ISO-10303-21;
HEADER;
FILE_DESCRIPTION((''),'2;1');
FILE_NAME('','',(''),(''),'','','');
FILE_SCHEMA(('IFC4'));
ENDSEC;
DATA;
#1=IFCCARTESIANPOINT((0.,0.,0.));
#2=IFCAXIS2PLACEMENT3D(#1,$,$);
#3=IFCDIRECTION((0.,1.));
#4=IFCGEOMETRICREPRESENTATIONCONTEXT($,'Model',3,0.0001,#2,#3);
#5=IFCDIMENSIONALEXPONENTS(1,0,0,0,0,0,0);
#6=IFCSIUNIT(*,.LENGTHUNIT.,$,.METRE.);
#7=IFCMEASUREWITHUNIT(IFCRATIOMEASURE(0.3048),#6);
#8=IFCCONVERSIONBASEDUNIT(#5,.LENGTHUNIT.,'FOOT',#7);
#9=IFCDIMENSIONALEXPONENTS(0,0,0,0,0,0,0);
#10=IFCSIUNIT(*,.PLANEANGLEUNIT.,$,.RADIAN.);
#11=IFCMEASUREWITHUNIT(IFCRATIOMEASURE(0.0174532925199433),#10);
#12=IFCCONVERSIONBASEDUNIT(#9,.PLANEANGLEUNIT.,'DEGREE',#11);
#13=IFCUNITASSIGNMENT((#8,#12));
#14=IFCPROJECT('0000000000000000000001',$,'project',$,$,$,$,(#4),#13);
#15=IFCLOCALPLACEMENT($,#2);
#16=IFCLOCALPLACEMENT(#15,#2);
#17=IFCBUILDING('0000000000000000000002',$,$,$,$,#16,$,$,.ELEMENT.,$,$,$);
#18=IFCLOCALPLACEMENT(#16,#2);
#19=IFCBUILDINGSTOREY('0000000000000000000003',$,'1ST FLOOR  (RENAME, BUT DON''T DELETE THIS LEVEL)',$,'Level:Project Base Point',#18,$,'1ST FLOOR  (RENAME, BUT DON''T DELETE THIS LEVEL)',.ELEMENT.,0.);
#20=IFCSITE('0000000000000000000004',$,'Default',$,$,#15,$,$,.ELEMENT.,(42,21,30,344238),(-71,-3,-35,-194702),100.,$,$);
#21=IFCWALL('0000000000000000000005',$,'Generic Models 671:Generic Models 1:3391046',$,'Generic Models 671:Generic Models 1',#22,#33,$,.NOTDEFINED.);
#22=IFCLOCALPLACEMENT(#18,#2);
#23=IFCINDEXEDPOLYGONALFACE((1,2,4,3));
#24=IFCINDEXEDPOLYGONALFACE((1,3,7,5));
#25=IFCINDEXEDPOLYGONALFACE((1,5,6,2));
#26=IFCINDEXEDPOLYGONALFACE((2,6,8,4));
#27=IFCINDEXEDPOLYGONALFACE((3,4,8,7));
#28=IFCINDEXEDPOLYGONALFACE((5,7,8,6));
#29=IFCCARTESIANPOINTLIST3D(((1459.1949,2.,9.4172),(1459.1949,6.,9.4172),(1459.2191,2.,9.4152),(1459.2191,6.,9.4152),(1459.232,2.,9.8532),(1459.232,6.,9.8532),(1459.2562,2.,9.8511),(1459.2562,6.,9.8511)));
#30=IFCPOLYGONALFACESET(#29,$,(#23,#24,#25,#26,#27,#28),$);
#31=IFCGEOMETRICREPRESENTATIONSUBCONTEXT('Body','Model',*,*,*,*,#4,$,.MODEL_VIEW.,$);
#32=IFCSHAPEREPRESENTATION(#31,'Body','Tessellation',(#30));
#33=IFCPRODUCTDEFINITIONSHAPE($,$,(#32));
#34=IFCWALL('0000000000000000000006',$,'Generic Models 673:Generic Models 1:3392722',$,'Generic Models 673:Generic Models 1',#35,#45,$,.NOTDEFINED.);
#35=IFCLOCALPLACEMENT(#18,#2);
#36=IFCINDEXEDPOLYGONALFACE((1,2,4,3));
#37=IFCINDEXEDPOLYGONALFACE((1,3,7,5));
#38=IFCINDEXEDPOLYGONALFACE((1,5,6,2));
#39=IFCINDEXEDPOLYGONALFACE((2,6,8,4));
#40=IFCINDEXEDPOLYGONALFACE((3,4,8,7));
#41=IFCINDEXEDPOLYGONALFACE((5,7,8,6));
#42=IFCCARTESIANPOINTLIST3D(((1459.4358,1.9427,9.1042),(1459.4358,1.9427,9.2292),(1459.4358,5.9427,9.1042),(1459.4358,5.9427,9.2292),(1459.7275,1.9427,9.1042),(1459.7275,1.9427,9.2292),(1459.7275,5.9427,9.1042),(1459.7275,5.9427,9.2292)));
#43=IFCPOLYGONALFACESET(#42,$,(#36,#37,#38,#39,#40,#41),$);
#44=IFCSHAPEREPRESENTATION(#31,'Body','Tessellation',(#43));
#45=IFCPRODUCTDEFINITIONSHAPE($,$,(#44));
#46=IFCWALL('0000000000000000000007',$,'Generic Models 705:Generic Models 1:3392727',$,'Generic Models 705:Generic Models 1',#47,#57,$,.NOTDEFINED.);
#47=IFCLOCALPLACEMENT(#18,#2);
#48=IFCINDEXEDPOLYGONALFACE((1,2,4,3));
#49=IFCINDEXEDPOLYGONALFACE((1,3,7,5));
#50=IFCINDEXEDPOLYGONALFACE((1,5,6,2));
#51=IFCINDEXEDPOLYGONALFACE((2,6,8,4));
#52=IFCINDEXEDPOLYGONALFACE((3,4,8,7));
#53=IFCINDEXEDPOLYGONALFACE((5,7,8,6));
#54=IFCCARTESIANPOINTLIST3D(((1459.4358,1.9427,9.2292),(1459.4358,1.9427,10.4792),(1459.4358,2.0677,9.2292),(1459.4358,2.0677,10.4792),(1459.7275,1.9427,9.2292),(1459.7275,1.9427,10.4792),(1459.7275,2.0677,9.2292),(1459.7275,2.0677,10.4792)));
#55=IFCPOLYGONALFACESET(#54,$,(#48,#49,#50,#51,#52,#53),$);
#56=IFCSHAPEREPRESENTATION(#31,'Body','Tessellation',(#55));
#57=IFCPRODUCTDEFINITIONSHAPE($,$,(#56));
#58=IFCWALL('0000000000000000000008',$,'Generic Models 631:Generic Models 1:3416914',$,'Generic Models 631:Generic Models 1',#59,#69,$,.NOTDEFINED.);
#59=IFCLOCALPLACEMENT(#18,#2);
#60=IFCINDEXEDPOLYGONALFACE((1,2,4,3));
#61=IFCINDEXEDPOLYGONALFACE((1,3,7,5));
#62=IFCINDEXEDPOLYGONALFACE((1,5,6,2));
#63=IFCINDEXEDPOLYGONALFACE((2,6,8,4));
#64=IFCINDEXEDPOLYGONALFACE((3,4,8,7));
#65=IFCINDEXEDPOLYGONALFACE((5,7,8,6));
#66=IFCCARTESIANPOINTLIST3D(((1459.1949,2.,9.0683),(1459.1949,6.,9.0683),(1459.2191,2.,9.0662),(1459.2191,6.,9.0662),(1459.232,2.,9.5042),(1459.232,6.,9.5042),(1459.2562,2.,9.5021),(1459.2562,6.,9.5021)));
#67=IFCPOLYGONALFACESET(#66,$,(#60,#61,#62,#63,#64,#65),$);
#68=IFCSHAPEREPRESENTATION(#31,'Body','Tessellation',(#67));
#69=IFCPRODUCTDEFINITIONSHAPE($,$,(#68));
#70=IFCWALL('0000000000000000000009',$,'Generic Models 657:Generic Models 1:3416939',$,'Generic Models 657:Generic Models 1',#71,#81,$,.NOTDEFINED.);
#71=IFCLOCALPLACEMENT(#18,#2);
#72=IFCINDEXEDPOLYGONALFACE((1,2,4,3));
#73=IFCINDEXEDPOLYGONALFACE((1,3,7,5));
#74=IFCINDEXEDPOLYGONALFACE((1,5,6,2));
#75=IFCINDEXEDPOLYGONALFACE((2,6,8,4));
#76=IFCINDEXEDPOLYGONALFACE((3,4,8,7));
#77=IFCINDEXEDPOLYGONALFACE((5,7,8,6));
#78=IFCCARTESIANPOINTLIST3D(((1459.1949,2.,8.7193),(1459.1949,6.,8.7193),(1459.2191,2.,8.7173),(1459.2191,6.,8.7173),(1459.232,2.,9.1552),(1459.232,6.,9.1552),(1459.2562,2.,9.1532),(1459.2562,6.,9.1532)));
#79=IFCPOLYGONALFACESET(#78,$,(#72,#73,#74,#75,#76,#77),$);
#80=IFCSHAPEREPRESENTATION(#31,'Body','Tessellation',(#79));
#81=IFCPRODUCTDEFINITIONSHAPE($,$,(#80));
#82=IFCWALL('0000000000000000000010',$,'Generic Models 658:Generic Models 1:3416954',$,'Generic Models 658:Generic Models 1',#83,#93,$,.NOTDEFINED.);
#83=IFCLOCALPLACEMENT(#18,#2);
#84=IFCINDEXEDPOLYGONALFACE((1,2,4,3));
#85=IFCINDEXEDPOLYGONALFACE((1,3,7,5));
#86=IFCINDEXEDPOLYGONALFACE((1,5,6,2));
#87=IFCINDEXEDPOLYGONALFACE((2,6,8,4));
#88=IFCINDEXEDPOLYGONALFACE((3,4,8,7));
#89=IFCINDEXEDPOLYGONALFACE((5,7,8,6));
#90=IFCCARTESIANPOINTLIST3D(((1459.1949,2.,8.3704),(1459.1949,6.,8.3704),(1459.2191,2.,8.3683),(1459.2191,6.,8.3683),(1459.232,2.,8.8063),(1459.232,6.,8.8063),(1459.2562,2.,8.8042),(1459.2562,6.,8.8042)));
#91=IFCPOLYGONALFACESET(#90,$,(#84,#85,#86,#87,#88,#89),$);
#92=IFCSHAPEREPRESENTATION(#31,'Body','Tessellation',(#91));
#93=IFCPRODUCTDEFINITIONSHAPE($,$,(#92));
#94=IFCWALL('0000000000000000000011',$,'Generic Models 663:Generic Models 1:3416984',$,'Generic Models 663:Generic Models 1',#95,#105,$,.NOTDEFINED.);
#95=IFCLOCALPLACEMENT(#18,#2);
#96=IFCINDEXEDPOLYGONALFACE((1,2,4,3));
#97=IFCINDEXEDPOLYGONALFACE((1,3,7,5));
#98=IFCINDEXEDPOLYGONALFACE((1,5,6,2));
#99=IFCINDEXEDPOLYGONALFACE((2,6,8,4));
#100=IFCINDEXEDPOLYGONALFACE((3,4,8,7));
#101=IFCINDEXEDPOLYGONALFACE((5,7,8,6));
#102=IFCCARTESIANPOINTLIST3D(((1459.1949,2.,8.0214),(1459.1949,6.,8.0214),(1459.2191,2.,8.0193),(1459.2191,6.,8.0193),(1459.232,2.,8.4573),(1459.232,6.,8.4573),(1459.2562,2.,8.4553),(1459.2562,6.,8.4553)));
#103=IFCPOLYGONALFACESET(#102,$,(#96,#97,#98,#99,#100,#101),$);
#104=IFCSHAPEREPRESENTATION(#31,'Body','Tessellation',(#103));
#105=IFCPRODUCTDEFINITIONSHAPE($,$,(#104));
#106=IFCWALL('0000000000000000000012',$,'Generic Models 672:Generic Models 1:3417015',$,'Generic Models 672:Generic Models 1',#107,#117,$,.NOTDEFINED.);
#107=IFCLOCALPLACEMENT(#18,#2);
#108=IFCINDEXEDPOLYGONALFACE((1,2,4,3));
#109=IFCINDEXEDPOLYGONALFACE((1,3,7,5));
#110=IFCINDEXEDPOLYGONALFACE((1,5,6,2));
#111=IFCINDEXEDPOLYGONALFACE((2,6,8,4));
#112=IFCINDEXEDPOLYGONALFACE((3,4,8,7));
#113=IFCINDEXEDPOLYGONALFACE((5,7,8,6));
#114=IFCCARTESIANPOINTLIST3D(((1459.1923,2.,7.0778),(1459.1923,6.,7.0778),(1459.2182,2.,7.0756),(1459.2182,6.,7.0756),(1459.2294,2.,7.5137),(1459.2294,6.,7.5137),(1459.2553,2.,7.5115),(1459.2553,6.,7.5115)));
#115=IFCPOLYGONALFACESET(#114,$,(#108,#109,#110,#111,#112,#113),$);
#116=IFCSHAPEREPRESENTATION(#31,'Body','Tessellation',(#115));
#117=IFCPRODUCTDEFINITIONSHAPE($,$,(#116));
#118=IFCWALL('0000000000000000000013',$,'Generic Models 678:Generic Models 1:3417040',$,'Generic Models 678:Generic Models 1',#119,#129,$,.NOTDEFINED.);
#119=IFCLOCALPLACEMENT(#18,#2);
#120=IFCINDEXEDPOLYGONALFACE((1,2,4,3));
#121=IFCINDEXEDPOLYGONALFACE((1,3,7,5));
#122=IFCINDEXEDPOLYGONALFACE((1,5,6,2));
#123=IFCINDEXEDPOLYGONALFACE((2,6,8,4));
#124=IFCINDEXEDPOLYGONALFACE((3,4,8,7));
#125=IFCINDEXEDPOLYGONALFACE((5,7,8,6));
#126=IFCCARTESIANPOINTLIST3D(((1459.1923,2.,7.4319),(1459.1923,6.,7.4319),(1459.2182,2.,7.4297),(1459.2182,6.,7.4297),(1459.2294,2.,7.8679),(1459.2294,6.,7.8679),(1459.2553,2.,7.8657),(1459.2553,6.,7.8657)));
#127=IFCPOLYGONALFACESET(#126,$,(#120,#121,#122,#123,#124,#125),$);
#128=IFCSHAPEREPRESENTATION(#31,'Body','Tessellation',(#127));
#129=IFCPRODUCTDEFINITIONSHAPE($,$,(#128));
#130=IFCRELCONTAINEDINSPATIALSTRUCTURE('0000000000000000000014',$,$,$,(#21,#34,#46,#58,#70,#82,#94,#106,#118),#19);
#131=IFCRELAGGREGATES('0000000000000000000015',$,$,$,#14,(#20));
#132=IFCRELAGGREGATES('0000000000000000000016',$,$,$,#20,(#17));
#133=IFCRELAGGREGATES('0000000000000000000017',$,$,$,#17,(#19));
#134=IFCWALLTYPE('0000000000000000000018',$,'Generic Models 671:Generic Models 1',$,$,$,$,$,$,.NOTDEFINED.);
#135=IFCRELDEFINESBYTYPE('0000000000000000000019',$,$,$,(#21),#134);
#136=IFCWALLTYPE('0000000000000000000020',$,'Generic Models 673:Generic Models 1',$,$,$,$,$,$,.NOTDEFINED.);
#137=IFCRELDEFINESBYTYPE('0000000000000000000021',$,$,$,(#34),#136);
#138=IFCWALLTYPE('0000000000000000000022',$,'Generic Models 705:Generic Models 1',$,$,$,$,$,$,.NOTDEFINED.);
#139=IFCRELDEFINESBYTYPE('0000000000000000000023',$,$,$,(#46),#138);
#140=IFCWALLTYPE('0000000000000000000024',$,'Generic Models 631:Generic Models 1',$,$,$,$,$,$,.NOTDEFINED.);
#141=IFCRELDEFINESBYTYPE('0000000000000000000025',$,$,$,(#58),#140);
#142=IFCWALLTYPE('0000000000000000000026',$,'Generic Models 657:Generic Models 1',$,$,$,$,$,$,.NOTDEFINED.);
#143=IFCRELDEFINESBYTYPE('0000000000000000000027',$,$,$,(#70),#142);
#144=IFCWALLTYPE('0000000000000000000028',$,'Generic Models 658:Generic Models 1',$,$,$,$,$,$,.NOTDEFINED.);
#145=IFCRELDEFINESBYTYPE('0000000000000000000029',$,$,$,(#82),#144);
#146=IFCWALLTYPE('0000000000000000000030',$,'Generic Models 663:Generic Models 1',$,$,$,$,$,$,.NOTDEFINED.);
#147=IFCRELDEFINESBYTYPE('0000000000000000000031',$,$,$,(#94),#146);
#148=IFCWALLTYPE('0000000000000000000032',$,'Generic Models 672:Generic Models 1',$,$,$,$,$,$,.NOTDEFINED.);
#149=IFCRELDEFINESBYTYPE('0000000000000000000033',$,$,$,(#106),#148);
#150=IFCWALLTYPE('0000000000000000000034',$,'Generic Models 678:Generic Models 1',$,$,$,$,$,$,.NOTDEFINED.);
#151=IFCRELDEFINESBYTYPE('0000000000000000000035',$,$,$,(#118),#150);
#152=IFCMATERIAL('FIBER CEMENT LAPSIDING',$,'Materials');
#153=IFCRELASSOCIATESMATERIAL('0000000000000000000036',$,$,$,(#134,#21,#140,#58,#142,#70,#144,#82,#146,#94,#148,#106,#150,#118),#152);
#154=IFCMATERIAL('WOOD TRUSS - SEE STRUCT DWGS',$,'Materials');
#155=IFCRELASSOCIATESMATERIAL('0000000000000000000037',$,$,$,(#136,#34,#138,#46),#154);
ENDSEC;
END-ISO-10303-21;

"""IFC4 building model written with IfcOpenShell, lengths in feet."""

from ifc_helpers import new_model, entity, si_unit, converted_unit, direction, frame, frame_2d, origin, place, context, subcontext, project, spatial, rectangle, extrude, material, type_object, element, save


model = new_model("IFC4")

# Units and contexts
model_context = context("Model", 3, precision=0.0001, world=origin(), true_north=direction((0.0, 1.0)))
body_context = subcontext(model_context, "Body", "Model", "MODEL_VIEW")
ifc_project = project(units=[converted_unit("LENGTHUNIT", "FOOT", entity("IfcRatioMeasure", 0.3048), si_unit("LENGTHUNIT", "METRE"), dimensions=[1, 0, 0, 0, 0, 0, 0]), converted_unit("PLANEANGLEUNIT", "DEGREE", entity("IfcRatioMeasure", 0.0174532925199433), si_unit("PLANEANGLEUNIT", "RADIAN"), dimensions=[0, 0, 0, 0, 0, 0, 0])], contexts=[model_context])

# Site, building, storey
site_placement = place(None, origin())
site = spatial("IfcSite", under=ifc_project, at=site_placement, Name="Default", CompositionType="ELEMENT", RefLatitude=(42, 21, 30, 344238), RefLongitude=(-71, -3, -35, -194702), RefElevation=100.0)
building_placement = place(site_placement, origin())
building = spatial("IfcBuilding", under=site, at=building_placement, CompositionType="ELEMENT")
storey_placement = place(building_placement, origin())
storey = spatial("IfcBuildingStorey", under=building, at=storey_placement, Name="1ST FLOOR  (RENAME, BUT DON'T DELETE THIS LEVEL)", ObjectType="Level:Project Base Point", LongName="1ST FLOOR  (RENAME, BUT DON'T DELETE THIS LEVEL)", CompositionType="ELEMENT", Elevation=0.0)

# Walls
ifc_material_1 = material(Name="FIBER CEMENT LAPSIDING", Category="Materials")
wall_type_1 = type_object("IfcWallType", Name="Generic Models 671:Generic Models 1", PredefinedType="NOTDEFINED", material=ifc_material_1)
wall_1_placement = place(storey_placement, frame((1459.1949, 2.0, 9.4152), z_axis=(0.0, 0.0, 1.0), x_axis=(0.0, 1.0, 0.0)))
element("IfcWall", 1, at=wall_1_placement, inside=storey, type_object=wall_type_1, material=ifc_material_1, Name="Generic Models 671:Generic Models 1:3391046", ObjectType="Generic Models 671:Generic Models 1", PredefinedType="NOTDEFINED", context=body_context, shape_type="SweptSolid", body=[
    extrude(rectangle(XDim=0.0242, YDim=4.0, at=frame_2d((0.0, 0.0), x_axis=(0.0, 1.0))), frame((2.0, -0.0121, 0.001), z_axis=(0.0, -0.0848, 0.996398), x_axis=(1.0, 0.0, 0.0)), (0.0, 0.0, 1.0), 0.4375),
])
ifc_material_2 = material(Name="WOOD TRUSS - SEE STRUCT DWGS", Category="Materials")
wall_type_2 = type_object("IfcWallType", Name="Generic Models 673:Generic Models 1", PredefinedType="NOTDEFINED", material=ifc_material_2)
wall_2_placement = place(storey_placement, frame((1459.4358, 1.9427, 9.1042), z_axis=(0.0, 0.0, 1.0), x_axis=(0.0, 1.0, 0.0)))
element("IfcWall", 2, at=wall_2_placement, inside=storey, type_object=wall_type_2, material=ifc_material_2, Name="Generic Models 673:Generic Models 1:3392722", ObjectType="Generic Models 673:Generic Models 1", PredefinedType="NOTDEFINED", context=body_context, shape_type="SweptSolid", body=[
    extrude(rectangle(XDim=4.0, YDim=0.2917, at=frame_2d((0.0, 0.0), x_axis=(1.0, 0.0))), frame((2.0, -0.1458, 0.0)), (0.0, 0.0, 1.0), 0.125),
])
wall_type_3 = type_object("IfcWallType", Name="Generic Models 705:Generic Models 1", PredefinedType="NOTDEFINED", material=ifc_material_2)
wall_3_placement = place(storey_placement, frame((1459.4358, 1.9427, 9.2292)))
element("IfcWall", 3, at=wall_3_placement, inside=storey, type_object=wall_type_3, material=ifc_material_2, Name="Generic Models 705:Generic Models 1:3392727", ObjectType="Generic Models 705:Generic Models 1", PredefinedType="NOTDEFINED", context=body_context, shape_type="SweptSolid", body=[
    extrude(rectangle(XDim=0.125, YDim=0.2917, at=frame_2d((0.0, 0.0), x_axis=(1.0, 0.0))), frame((0.1458, 0.0625, 0.0), z_axis=(0.0, 0.0, 1.0), x_axis=(0.0, 1.0, 0.0)), (0.0, 0.0, 1.0), 1.25),
])
wall_type_4 = type_object("IfcWallType", Name="Generic Models 631:Generic Models 1", PredefinedType="NOTDEFINED", material=ifc_material_1)
wall_4_placement = place(storey_placement, frame((1459.1949, 2.0, 9.0662), z_axis=(0.0, 0.0, 1.0), x_axis=(0.0, 1.0, 0.0)))
element("IfcWall", 4, at=wall_4_placement, inside=storey, type_object=wall_type_4, material=ifc_material_1, Name="Generic Models 631:Generic Models 1:3416914", ObjectType="Generic Models 631:Generic Models 1", PredefinedType="NOTDEFINED", context=body_context, shape_type="SweptSolid", body=[
    extrude(rectangle(XDim=0.0242, YDim=4.0, at=frame_2d((0.0, 0.0), x_axis=(0.0, 1.0))), frame((2.0, -0.0121, 0.001), z_axis=(0.0, -0.0848, 0.996398), x_axis=(1.0, 0.0, 0.0)), (0.0, 0.0, 1.0), 0.4375),
])
wall_type_5 = type_object("IfcWallType", Name="Generic Models 657:Generic Models 1", PredefinedType="NOTDEFINED", material=ifc_material_1)
wall_5_placement = place(storey_placement, frame((1459.1949, 2.0, 8.7173), z_axis=(0.0, 0.0, 1.0), x_axis=(0.0, 1.0, 0.0)))
element("IfcWall", 5, at=wall_5_placement, inside=storey, type_object=wall_type_5, material=ifc_material_1, Name="Generic Models 657:Generic Models 1:3416939", ObjectType="Generic Models 657:Generic Models 1", PredefinedType="NOTDEFINED", context=body_context, shape_type="SweptSolid", body=[
    extrude(rectangle(XDim=0.0242, YDim=4.0, at=frame_2d((0.0, 0.0), x_axis=(0.0, 1.0))), frame((2.0, -0.0121, 0.001), z_axis=(0.0, -0.0848, 0.996398), x_axis=(1.0, 0.0, 0.0)), (0.0, 0.0, 1.0), 0.4375),
])
wall_type_6 = type_object("IfcWallType", Name="Generic Models 658:Generic Models 1", PredefinedType="NOTDEFINED", material=ifc_material_1)
wall_6_placement = place(storey_placement, frame((1459.1949, 2.0, 8.3683), z_axis=(0.0, 0.0, 1.0), x_axis=(0.0, 1.0, 0.0)))
element("IfcWall", 6, at=wall_6_placement, inside=storey, type_object=wall_type_6, material=ifc_material_1, Name="Generic Models 658:Generic Models 1:3416954", ObjectType="Generic Models 658:Generic Models 1", PredefinedType="NOTDEFINED", context=body_context, shape_type="SweptSolid", body=[
    extrude(rectangle(XDim=0.0242, YDim=4.0, at=frame_2d((0.0, 0.0), x_axis=(0.0, 1.0))), frame((2.0, -0.0121, 0.001), z_axis=(0.0, -0.0848, 0.996398), x_axis=(1.0, 0.0, 0.0)), (0.0, 0.0, 1.0), 0.4375),
])
wall_type_7 = type_object("IfcWallType", Name="Generic Models 663:Generic Models 1", PredefinedType="NOTDEFINED", material=ifc_material_1)
wall_7_placement = place(storey_placement, frame((1459.1949, 2.0, 8.0193), z_axis=(0.0, 0.0, 1.0), x_axis=(0.0, 1.0, 0.0)))
element("IfcWall", 7, at=wall_7_placement, inside=storey, type_object=wall_type_7, material=ifc_material_1, Name="Generic Models 663:Generic Models 1:3416984", ObjectType="Generic Models 663:Generic Models 1", PredefinedType="NOTDEFINED", context=body_context, shape_type="SweptSolid", body=[
    extrude(rectangle(XDim=0.0242, YDim=4.0, at=frame_2d((0.0, 0.0), x_axis=(0.0, 1.0))), frame((2.0, -0.0121, 0.001), z_axis=(0.0, -0.0848, 0.996398), x_axis=(1.0, 0.0, 0.0)), (0.0, 0.0, 1.0), 0.4375),
])
wall_type_8 = type_object("IfcWallType", Name="Generic Models 672:Generic Models 1", PredefinedType="NOTDEFINED", material=ifc_material_1)
wall_8_placement = place(storey_placement, frame((1459.1923, 2.0, 7.0756), z_axis=(0.0, 0.0, 1.0), x_axis=(0.0, 1.0, 0.0)))
element("IfcWall", 8, at=wall_8_placement, inside=storey, type_object=wall_type_8, material=ifc_material_1, Name="Generic Models 672:Generic Models 1:3417015", ObjectType="Generic Models 672:Generic Models 1", PredefinedType="NOTDEFINED", context=body_context, shape_type="SweptSolid", body=[
    extrude(rectangle(XDim=0.026, YDim=4.0, at=frame_2d((0.0, 0.0), x_axis=(0.0, 1.0))), frame((2.0, -0.013, 0.0011), z_axis=(0.0, -0.0848, 0.996398), x_axis=(1.0, 0.0, 0.0)), (0.0, 0.0, 1.0), 0.4375),
])
wall_type_9 = type_object("IfcWallType", Name="Generic Models 678:Generic Models 1", PredefinedType="NOTDEFINED", material=ifc_material_1)
wall_9_placement = place(storey_placement, frame((1459.1923, 2.0, 7.4297), z_axis=(0.0, 0.0, 1.0), x_axis=(0.0, 1.0, 0.0)))
element("IfcWall", 9, at=wall_9_placement, inside=storey, type_object=wall_type_9, material=ifc_material_1, Name="Generic Models 678:Generic Models 1:3417040", ObjectType="Generic Models 678:Generic Models 1", PredefinedType="NOTDEFINED", context=body_context, shape_type="SweptSolid", body=[
    extrude(rectangle(XDim=0.026, YDim=4.0, at=frame_2d((0.0, 0.0), x_axis=(0.0, 1.0))), frame((2.0, -0.013, 0.0011), z_axis=(0.0, -0.0848, 0.996398), x_axis=(1.0, 0.0, 0.0)), (0.0, 0.0, 1.0), 0.4375),
])

save(model, "model.ifc")
